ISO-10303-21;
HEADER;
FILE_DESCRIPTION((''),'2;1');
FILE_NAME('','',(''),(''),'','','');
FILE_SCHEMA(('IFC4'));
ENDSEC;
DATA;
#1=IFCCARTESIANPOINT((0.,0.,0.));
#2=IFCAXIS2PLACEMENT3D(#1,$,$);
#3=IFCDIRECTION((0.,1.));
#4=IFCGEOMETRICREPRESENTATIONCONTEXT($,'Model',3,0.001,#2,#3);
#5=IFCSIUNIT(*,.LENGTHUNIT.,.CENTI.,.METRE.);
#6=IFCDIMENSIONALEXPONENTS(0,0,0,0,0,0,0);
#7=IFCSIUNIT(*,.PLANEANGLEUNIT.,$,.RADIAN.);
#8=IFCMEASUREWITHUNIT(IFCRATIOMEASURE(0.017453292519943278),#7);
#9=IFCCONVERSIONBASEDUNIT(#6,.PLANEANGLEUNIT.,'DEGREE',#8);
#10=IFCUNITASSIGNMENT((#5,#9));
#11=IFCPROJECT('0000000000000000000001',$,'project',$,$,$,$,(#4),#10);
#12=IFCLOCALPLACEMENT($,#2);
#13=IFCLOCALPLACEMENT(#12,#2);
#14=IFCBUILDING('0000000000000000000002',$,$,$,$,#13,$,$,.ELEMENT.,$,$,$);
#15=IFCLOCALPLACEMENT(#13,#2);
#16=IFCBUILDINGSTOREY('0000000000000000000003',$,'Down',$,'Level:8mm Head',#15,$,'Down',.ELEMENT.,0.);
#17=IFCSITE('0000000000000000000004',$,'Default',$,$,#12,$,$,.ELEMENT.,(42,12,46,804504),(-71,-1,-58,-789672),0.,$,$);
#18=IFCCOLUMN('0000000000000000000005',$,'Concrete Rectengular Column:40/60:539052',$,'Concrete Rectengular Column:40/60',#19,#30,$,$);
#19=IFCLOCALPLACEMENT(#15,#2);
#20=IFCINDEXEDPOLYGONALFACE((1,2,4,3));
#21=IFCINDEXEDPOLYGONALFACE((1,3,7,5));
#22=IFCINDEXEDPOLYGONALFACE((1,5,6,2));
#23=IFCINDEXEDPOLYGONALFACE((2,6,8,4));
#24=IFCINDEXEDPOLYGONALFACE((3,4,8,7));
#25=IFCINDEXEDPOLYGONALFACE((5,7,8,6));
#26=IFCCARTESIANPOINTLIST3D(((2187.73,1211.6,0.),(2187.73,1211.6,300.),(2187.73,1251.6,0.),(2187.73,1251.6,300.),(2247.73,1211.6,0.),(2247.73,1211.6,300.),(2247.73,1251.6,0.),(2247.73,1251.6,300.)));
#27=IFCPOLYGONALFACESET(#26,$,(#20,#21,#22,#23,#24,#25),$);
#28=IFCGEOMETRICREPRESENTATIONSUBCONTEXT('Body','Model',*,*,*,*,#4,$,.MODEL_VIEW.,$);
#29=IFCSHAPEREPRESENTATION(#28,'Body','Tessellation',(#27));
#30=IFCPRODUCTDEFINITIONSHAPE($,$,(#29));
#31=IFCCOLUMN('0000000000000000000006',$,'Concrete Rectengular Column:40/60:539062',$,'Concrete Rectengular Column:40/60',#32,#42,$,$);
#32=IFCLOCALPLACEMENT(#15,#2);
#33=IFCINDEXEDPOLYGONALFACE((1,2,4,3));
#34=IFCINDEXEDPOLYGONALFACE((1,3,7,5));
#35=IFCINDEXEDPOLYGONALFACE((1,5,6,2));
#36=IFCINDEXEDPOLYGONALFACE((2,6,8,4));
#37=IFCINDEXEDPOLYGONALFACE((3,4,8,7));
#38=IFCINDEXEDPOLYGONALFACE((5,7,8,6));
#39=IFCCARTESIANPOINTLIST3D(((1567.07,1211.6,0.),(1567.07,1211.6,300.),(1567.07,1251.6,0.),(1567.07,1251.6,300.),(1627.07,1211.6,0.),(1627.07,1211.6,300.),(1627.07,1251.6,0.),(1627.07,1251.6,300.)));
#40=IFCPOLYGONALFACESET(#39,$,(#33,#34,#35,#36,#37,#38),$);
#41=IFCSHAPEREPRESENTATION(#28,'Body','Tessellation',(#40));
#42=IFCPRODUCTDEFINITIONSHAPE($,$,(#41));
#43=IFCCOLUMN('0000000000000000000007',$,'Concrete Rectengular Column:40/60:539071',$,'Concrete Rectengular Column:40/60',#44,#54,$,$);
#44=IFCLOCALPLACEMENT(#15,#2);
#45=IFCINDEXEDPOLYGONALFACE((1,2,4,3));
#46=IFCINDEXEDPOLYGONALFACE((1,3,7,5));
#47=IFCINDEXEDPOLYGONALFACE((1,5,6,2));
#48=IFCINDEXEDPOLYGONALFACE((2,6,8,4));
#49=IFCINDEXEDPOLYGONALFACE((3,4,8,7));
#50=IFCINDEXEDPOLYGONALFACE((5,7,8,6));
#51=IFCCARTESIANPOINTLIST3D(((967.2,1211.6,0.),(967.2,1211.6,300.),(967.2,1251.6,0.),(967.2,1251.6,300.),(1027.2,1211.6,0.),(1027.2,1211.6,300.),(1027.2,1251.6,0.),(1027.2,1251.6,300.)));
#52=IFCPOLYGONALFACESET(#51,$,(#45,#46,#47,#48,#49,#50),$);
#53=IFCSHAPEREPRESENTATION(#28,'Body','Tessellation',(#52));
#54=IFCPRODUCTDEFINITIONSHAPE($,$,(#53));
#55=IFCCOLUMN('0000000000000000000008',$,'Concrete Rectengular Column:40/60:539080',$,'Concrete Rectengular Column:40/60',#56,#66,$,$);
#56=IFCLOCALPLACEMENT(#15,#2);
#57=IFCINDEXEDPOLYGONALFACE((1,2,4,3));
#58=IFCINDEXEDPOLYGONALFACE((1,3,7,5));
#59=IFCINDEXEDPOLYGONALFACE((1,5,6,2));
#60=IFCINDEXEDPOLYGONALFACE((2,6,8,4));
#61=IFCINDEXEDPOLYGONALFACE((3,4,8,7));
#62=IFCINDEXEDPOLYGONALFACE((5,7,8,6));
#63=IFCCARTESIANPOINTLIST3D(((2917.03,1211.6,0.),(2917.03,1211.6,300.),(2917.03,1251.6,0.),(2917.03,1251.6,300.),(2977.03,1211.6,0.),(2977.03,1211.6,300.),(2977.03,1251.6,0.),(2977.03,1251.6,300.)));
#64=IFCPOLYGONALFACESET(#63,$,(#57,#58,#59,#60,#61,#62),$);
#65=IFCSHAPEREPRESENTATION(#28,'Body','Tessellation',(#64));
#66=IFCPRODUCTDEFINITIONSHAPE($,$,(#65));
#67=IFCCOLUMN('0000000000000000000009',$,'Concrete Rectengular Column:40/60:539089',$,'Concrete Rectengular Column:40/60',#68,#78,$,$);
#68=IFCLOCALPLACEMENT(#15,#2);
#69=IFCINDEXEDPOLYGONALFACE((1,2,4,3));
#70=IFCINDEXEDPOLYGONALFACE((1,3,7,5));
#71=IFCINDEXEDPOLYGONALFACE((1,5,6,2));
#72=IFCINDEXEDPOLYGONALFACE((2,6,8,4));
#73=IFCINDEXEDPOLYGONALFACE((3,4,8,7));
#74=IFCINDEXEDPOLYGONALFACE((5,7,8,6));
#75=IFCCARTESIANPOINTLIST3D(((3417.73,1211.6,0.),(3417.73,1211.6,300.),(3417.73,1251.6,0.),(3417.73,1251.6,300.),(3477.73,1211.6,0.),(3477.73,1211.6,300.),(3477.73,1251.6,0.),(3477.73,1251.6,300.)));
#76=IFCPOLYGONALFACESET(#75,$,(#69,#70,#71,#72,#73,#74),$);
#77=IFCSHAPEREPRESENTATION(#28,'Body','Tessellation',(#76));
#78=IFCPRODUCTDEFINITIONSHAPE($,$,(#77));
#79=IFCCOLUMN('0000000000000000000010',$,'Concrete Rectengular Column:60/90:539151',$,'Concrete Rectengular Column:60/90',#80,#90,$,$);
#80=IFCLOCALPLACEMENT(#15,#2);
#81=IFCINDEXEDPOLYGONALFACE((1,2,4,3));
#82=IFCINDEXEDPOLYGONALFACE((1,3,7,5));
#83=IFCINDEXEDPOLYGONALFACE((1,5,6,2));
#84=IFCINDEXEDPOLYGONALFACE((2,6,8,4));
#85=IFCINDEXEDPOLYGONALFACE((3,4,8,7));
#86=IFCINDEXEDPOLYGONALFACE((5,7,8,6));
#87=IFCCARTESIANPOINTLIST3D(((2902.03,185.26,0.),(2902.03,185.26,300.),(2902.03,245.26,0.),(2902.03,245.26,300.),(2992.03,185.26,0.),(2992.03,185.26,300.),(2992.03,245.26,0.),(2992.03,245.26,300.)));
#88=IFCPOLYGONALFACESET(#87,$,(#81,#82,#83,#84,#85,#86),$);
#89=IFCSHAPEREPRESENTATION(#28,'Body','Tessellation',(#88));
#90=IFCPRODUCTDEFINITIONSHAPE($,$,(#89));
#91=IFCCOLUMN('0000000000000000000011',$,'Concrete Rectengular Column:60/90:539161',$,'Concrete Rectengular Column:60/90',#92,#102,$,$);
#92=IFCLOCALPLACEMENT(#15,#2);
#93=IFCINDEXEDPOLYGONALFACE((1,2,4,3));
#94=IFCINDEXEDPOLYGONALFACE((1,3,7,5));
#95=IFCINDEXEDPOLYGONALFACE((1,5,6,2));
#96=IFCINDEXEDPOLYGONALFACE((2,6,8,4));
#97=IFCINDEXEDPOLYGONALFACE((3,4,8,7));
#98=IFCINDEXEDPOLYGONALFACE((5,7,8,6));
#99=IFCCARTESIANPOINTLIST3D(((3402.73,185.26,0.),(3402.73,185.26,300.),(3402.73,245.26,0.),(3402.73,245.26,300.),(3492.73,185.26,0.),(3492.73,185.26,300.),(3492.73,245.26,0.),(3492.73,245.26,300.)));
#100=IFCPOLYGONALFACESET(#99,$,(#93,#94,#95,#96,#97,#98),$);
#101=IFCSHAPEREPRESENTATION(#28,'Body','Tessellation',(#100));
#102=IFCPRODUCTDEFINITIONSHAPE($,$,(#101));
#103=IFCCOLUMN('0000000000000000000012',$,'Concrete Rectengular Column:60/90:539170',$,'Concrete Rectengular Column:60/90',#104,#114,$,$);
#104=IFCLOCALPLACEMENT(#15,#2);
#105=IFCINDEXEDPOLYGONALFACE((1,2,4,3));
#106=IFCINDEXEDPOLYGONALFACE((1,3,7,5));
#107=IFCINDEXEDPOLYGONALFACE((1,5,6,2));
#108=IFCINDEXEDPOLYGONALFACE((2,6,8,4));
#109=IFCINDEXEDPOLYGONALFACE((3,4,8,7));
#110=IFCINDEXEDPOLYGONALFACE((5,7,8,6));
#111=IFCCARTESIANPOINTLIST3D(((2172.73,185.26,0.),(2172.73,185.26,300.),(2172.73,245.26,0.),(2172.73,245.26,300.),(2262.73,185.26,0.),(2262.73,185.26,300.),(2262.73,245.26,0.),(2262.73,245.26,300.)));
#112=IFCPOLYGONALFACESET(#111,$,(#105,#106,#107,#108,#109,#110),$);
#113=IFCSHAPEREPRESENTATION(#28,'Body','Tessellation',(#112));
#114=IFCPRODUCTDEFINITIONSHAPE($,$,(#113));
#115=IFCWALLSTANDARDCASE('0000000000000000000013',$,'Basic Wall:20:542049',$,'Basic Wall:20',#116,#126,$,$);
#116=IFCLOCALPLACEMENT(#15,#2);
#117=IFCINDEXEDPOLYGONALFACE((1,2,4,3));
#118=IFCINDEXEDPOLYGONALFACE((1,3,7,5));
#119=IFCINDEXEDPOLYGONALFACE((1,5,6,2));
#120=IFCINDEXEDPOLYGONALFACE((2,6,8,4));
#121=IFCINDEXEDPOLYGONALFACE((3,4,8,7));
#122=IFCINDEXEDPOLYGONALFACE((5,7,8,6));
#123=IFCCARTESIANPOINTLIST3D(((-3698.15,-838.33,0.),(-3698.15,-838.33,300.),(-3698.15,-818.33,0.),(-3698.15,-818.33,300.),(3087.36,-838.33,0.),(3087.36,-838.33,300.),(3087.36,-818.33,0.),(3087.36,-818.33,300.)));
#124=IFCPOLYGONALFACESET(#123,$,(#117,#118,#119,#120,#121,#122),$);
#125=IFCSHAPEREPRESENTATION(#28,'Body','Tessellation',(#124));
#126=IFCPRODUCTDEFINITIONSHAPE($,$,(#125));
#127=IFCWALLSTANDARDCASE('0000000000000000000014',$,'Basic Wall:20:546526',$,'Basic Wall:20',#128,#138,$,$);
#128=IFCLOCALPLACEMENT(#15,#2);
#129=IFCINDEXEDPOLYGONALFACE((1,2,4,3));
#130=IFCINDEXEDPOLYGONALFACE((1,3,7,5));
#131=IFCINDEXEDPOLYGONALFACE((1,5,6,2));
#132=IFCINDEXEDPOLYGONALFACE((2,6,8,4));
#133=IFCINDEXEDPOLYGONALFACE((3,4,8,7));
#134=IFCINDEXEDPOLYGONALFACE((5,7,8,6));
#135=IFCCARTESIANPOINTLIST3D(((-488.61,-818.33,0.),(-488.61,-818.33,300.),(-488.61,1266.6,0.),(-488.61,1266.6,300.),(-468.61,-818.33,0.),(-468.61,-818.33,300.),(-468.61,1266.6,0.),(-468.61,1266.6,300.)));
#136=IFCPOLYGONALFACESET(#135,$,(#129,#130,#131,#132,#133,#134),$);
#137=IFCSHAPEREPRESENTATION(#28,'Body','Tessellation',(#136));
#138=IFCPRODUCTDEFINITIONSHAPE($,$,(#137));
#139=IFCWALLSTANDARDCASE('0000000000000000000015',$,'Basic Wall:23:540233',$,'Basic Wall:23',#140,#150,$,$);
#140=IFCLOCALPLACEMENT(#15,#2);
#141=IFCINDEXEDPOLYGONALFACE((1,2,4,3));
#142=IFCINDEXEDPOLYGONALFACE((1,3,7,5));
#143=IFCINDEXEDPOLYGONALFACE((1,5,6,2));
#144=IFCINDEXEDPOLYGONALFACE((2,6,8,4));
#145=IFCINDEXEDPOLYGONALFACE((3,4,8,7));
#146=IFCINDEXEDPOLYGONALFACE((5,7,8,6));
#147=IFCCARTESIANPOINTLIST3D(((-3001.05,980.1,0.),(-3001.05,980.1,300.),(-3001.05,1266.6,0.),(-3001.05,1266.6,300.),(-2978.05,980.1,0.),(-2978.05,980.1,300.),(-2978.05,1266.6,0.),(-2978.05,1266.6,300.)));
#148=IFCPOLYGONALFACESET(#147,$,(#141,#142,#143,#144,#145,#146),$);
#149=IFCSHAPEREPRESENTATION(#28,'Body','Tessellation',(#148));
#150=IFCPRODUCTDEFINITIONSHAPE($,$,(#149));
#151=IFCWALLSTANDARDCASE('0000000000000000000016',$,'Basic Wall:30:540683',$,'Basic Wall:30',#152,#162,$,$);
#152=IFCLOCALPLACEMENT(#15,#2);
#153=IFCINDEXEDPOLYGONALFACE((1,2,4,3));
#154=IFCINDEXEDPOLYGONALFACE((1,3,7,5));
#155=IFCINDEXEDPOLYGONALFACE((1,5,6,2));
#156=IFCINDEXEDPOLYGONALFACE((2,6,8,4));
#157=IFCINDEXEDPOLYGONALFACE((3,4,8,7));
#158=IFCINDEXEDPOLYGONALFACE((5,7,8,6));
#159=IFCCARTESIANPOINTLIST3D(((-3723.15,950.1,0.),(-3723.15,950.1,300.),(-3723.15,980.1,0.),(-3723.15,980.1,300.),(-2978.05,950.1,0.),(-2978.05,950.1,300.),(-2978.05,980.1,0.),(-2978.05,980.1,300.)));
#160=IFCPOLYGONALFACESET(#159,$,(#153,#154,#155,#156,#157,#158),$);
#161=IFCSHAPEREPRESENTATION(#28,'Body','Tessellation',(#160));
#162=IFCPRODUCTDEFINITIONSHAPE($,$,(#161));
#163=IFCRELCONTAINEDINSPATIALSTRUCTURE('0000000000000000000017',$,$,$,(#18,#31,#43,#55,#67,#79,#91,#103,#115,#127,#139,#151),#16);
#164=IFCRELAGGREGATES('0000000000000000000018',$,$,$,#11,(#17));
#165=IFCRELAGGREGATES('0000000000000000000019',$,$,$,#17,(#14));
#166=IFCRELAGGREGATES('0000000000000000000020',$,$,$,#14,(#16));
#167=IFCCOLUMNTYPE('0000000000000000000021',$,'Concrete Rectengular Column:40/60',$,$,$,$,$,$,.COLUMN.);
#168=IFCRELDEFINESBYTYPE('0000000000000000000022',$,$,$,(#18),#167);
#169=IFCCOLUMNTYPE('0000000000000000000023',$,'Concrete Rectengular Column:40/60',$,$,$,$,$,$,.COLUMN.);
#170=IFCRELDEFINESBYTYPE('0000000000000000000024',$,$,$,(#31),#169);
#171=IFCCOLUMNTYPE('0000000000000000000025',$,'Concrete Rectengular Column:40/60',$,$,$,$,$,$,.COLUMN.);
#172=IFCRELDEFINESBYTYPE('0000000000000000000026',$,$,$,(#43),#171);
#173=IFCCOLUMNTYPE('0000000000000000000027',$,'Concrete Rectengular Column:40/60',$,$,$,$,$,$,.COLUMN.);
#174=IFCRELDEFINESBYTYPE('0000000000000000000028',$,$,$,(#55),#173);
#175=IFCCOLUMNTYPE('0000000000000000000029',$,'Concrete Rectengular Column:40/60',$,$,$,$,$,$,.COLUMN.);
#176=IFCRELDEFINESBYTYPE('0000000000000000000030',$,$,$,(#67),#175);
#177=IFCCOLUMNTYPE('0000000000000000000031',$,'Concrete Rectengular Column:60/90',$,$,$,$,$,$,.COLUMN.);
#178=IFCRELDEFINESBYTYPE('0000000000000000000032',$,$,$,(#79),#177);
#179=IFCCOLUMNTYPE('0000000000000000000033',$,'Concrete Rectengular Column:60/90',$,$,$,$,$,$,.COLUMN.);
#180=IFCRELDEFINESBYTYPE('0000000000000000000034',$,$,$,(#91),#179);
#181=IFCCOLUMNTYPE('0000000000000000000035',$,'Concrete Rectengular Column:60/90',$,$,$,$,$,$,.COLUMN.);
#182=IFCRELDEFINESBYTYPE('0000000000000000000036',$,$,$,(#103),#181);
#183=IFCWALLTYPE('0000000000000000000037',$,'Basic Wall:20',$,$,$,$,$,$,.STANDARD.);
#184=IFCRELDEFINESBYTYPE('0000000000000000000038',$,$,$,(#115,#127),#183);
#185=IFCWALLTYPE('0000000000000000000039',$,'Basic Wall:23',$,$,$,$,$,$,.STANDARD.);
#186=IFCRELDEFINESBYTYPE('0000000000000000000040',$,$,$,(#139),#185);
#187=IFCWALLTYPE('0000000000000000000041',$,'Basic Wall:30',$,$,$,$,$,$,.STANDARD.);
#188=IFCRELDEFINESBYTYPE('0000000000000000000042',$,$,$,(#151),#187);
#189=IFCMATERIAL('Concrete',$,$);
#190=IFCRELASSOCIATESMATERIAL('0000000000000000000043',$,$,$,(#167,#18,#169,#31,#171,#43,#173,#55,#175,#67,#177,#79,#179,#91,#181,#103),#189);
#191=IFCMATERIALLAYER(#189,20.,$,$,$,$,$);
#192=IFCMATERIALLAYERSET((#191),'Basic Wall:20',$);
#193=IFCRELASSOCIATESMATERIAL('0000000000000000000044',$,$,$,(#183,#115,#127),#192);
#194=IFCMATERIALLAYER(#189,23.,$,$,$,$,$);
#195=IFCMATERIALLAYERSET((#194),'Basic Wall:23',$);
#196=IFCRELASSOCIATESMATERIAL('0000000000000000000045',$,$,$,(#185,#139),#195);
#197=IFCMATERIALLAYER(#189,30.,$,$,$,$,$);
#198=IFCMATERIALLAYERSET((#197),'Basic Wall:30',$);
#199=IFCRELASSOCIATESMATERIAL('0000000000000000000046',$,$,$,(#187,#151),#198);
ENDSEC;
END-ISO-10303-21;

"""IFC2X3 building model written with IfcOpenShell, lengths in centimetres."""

from ifc_helpers import new_model, entity, si_unit, converted_unit, direction, frame, frame_2d, origin, origin_2d_with_axis, place, context, subcontext, project, spatial, rectangle, extrude, source, transform, mapped, material, layer, layer_set, layer_usage, type_object, type_shapes, element, save


model = new_model("IFC2X3")

# Units and contexts
model_context = context("Model", 3, precision=0.001, world=origin(), true_north=direction((0.0, 1.0)))
body_context = subcontext(model_context, "Body", "Model", "MODEL_VIEW")
ifc_project = project(units=[si_unit("LENGTHUNIT", "METRE", prefix="CENTI"), converted_unit("PLANEANGLEUNIT", "DEGREE", entity("IfcRatioMeasure", 0.017453292519943278), si_unit("PLANEANGLEUNIT", "RADIAN"), dimensions=[0, 0, 0, 0, 0, 0, 0])], contexts=[model_context])

# Site, building, storey
site_placement = place(None, origin())
site = spatial("IfcSite", under=ifc_project, at=site_placement, Name="Default", CompositionType="ELEMENT", RefLatitude=(42, 12, 46, 804504), RefLongitude=(-71, -1, -58, -789672), RefElevation=0.0)
building_placement = place(site_placement, origin())
building = spatial("IfcBuilding", under=site, at=building_placement, CompositionType="ELEMENT")
storey_placement = place(building_placement, origin())
storey = spatial("IfcBuildingStorey", under=building, at=storey_placement, Name="Down", ObjectType="Level:8mm Head", LongName="Down", CompositionType="ELEMENT", Elevation=0.0)

# Columns
ifc_material = material(Name="Concrete")
column_type_1 = type_object("IfcColumnType", Name="Concrete Rectengular Column:40/60", PredefinedType="COLUMN", material=ifc_material)
shared_shape_1 = source(origin(), body_context, "Body", "SweptSolid", [
    extrude(rectangle(XDim=40.0, YDim=60.0, at=origin_2d_with_axis()), frame((2217.73, 1231.6, 0.0), z_axis=(0.0, 0.0, 1.0), x_axis=(0.0, -1.0, 0.0)), (0.0, 0.0, 1.0), 300.0),
])
type_shapes(column_type_1, [shared_shape_1])
column_1_placement = place(storey_placement, origin())
element("IfcColumn", 1, at=column_1_placement, inside=storey, type_object=column_type_1, material=ifc_material, Name="Concrete Rectengular Column:40/60:539052", ObjectType="Concrete Rectengular Column:40/60", context=body_context, shape_type="MappedRepresentation", body=[
    mapped(shared_shape_1, transform((0.0, 0.0, 0.0), scale=1.0)),
])
column_type_2 = type_object("IfcColumnType", Name="Concrete Rectengular Column:40/60", PredefinedType="COLUMN", material=ifc_material)
shared_shape_2 = source(origin(), body_context, "Body", "SweptSolid", [
    extrude(rectangle(XDim=40.0, YDim=60.0, at=origin_2d_with_axis()), frame((1597.07, 1231.6, 0.0), z_axis=(0.0, 0.0, 1.0), x_axis=(0.0, -1.0, 0.0)), (0.0, 0.0, 1.0), 300.0),
])
type_shapes(column_type_2, [shared_shape_2])
column_2_placement = place(storey_placement, origin())
element("IfcColumn", 2, at=column_2_placement, inside=storey, type_object=column_type_2, material=ifc_material, Name="Concrete Rectengular Column:40/60:539062", ObjectType="Concrete Rectengular Column:40/60", context=body_context, shape_type="MappedRepresentation", body=[
    mapped(shared_shape_2, transform((0.0, 0.0, 0.0), scale=1.0)),
])
column_type_3 = type_object("IfcColumnType", Name="Concrete Rectengular Column:40/60", PredefinedType="COLUMN", material=ifc_material)
shared_shape_3 = source(origin(), body_context, "Body", "SweptSolid", [
    extrude(rectangle(XDim=40.0, YDim=60.0, at=frame_2d((0.0, 0.0), x_axis=(1.0, 0.0))), frame((997.2, 1231.6, 0.0), z_axis=(0.0, 0.0, 1.0), x_axis=(0.0, -1.0, 0.0)), (0.0, 0.0, 1.0), 300.0),
])
type_shapes(column_type_3, [shared_shape_3])
column_3_placement = place(storey_placement, origin())
element("IfcColumn", 3, at=column_3_placement, inside=storey, type_object=column_type_3, material=ifc_material, Name="Concrete Rectengular Column:40/60:539071", ObjectType="Concrete Rectengular Column:40/60", context=body_context, shape_type="MappedRepresentation", body=[
    mapped(shared_shape_3, transform((0.0, 0.0, 0.0), scale=1.0)),
])
column_type_4 = type_object("IfcColumnType", Name="Concrete Rectengular Column:40/60", PredefinedType="COLUMN", material=ifc_material)
shared_shape_4 = source(origin(), body_context, "Body", "SweptSolid", [
    extrude(rectangle(XDim=40.0, YDim=60.0, at=origin_2d_with_axis()), frame((2947.03, 1231.6, 0.0), z_axis=(0.0, 0.0, 1.0), x_axis=(0.0, -1.0, 0.0)), (0.0, 0.0, 1.0), 300.0),
])
type_shapes(column_type_4, [shared_shape_4])
column_4_placement = place(storey_placement, origin())
element("IfcColumn", 4, at=column_4_placement, inside=storey, type_object=column_type_4, material=ifc_material, Name="Concrete Rectengular Column:40/60:539080", ObjectType="Concrete Rectengular Column:40/60", context=body_context, shape_type="MappedRepresentation", body=[
    mapped(shared_shape_4, transform((0.0, 0.0, 0.0), scale=1.0)),
])
column_type_5 = type_object("IfcColumnType", Name="Concrete Rectengular Column:40/60", PredefinedType="COLUMN", material=ifc_material)
shared_shape_5 = source(origin(), body_context, "Body", "SweptSolid", [
    extrude(rectangle(XDim=40.0, YDim=60.0, at=origin_2d_with_axis()), frame((3447.73, 1231.6, 0.0), z_axis=(0.0, 0.0, 1.0), x_axis=(0.0, -1.0, 0.0)), (0.0, 0.0, 1.0), 300.0),
])
type_shapes(column_type_5, [shared_shape_5])
column_5_placement = place(storey_placement, origin())
element("IfcColumn", 5, at=column_5_placement, inside=storey, type_object=column_type_5, material=ifc_material, Name="Concrete Rectengular Column:40/60:539089", ObjectType="Concrete Rectengular Column:40/60", context=body_context, shape_type="MappedRepresentation", body=[
    mapped(shared_shape_5, transform((0.0, 0.0, 0.0), scale=1.0)),
])
column_type_6 = type_object("IfcColumnType", Name="Concrete Rectengular Column:60/90", PredefinedType="COLUMN", material=ifc_material)
shared_shape_6 = source(origin(), body_context, "Body", "SweptSolid", [
    extrude(rectangle(XDim=60.0, YDim=90.0, at=frame_2d((0.0, 0.0), x_axis=(1.0, 0.0))), frame((2947.03, 215.26, 0.0), z_axis=(0.0, 0.0, 1.0), x_axis=(0.0, -1.0, 0.0)), (0.0, 0.0, 1.0), 300.0),
])
type_shapes(column_type_6, [shared_shape_6])
column_6_placement = place(storey_placement, origin())
element("IfcColumn", 6, at=column_6_placement, inside=storey, type_object=column_type_6, material=ifc_material, Name="Concrete Rectengular Column:60/90:539151", ObjectType="Concrete Rectengular Column:60/90", context=body_context, shape_type="MappedRepresentation", body=[
    mapped(shared_shape_6, transform((0.0, 0.0, 0.0), scale=1.0)),
])
column_type_7 = type_object("IfcColumnType", Name="Concrete Rectengular Column:60/90", PredefinedType="COLUMN", material=ifc_material)
shared_shape_7 = source(origin(), body_context, "Body", "SweptSolid", [
    extrude(rectangle(XDim=60.0, YDim=90.0, at=frame_2d((0.0, 0.0), x_axis=(1.0, 0.0))), frame((3447.73, 215.26, 0.0), z_axis=(0.0, 0.0, 1.0), x_axis=(0.0, -1.0, 0.0)), (0.0, 0.0, 1.0), 300.0),
])
type_shapes(column_type_7, [shared_shape_7])
column_7_placement = place(storey_placement, origin())
element("IfcColumn", 7, at=column_7_placement, inside=storey, type_object=column_type_7, material=ifc_material, Name="Concrete Rectengular Column:60/90:539161", ObjectType="Concrete Rectengular Column:60/90", context=body_context, shape_type="MappedRepresentation", body=[
    mapped(shared_shape_7, transform((0.0, 0.0, 0.0), scale=1.0)),
])
column_type_8 = type_object("IfcColumnType", Name="Concrete Rectengular Column:60/90", PredefinedType="COLUMN", material=ifc_material)
shared_shape_8 = source(origin(), body_context, "Body", "SweptSolid", [
    extrude(rectangle(XDim=60.0, YDim=90.0, at=frame_2d((0.0, 0.0), x_axis=(1.0, 0.0))), frame((2217.73, 215.26, 0.0), z_axis=(0.0, 0.0, 1.0), x_axis=(0.0, -1.0, 0.0)), (0.0, 0.0, 1.0), 300.0),
])
type_shapes(column_type_8, [shared_shape_8])
column_8_placement = place(storey_placement, origin())
element("IfcColumn", 8, at=column_8_placement, inside=storey, type_object=column_type_8, material=ifc_material, Name="Concrete Rectengular Column:60/90:539170", ObjectType="Concrete Rectengular Column:60/90", context=body_context, shape_type="MappedRepresentation", body=[
    mapped(shared_shape_8, transform((0.0, 0.0, 0.0), scale=1.0)),
])

# Walls
ifc_layer_1 = layer(ifc_material, 20.0)
ifc_layer_set_1 = layer_set([ifc_layer_1], Name="Basic Wall:20")
ifc_layer_usage_1 = layer_usage(ifc_layer_set_1, "AXIS2", "POSITIVE", -10.0)
wall_type_1 = type_object("IfcWallType", Name="Basic Wall:20", PredefinedType="STANDARD", material=ifc_layer_set_1)
wall_1_placement = place(storey_placement, frame((-3698.15, -828.33, 0.0)))
element("IfcWallStandardCase", 9, at=wall_1_placement, inside=storey, type_object=wall_type_1, material=ifc_layer_usage_1, Name="Basic Wall:20:542049", ObjectType="Basic Wall:20", context=body_context, shape_type="SweptSolid", body=[
    extrude(rectangle(XDim=6785.52, YDim=20.0, at=frame_2d((3392.76, 0.0), x_axis=(-1.0, 0.0))), origin(), (0.0, 0.0, 1.0), 300.0),
])
ifc_layer_usage_2 = layer_usage(ifc_layer_set_1, "AXIS2", "NEGATIVE", 10.0)
wall_2_placement = place(storey_placement, frame((-478.61, 1266.6, 0.0), z_axis=(0.0, 0.0, 1.0), x_axis=(0.0, -1.0, 0.0)))
element("IfcWallStandardCase", 10, at=wall_2_placement, inside=storey, type_object=wall_type_1, material=ifc_layer_usage_2, Name="Basic Wall:20:546526", ObjectType="Basic Wall:20", context=body_context, shape_type="SweptSolid", body=[
    extrude(rectangle(XDim=2084.93, YDim=20.0, at=frame_2d((1042.47, 0.0), x_axis=(-1.0, 0.0))), origin(), (0.0, 0.0, 1.0), 300.0),
])
ifc_layer_2 = layer(ifc_material, 23.0)
ifc_layer_set_2 = layer_set([ifc_layer_2], Name="Basic Wall:23")
ifc_layer_usage_3 = layer_usage(ifc_layer_set_2, "AXIS2", "NEGATIVE", 11.5)
wall_type_2 = type_object("IfcWallType", Name="Basic Wall:23", PredefinedType="STANDARD", material=ifc_layer_set_2)
wall_3_placement = place(storey_placement, frame((-2989.55, 1266.6, 0.0), z_axis=(0.0, 0.0, 1.0), x_axis=(0.0, -1.0, 0.0)))
element("IfcWallStandardCase", 11, at=wall_3_placement, inside=storey, type_object=wall_type_2, material=ifc_layer_usage_3, Name="Basic Wall:23:540233", ObjectType="Basic Wall:23", context=body_context, shape_type="SweptSolid", body=[
    extrude(rectangle(XDim=286.5, YDim=23.0, at=frame_2d((143.25, 0.0), x_axis=(-1.0, 0.0))), origin(), (0.0, 0.0, 1.0), 300.0),
])
ifc_layer_3 = layer(ifc_material, 30.0)
ifc_layer_set_3 = layer_set([ifc_layer_3], Name="Basic Wall:30")
ifc_layer_usage_4 = layer_usage(ifc_layer_set_3, "AXIS2", "NEGATIVE", 15.0)
wall_type_3 = type_object("IfcWallType", Name="Basic Wall:30", PredefinedType="STANDARD", material=ifc_layer_set_3)
wall_4_placement = place(storey_placement, frame((-2978.05, 965.1, 0.0), z_axis=(0.0, 0.0, 1.0), x_axis=(-1.0, 0.0, 0.0)))
element("IfcWallStandardCase", 12, at=wall_4_placement, inside=storey, type_object=wall_type_3, material=ifc_layer_usage_4, Name="Basic Wall:30:540683", ObjectType="Basic Wall:30", context=body_context, shape_type="SweptSolid", body=[
    extrude(rectangle(XDim=745.11, YDim=30.0, at=frame_2d((372.55, 0.0), x_axis=(-1.0, 0.0))), origin(), (0.0, 0.0, 1.0), 300.0),
])

save(model, "model.ifc")
